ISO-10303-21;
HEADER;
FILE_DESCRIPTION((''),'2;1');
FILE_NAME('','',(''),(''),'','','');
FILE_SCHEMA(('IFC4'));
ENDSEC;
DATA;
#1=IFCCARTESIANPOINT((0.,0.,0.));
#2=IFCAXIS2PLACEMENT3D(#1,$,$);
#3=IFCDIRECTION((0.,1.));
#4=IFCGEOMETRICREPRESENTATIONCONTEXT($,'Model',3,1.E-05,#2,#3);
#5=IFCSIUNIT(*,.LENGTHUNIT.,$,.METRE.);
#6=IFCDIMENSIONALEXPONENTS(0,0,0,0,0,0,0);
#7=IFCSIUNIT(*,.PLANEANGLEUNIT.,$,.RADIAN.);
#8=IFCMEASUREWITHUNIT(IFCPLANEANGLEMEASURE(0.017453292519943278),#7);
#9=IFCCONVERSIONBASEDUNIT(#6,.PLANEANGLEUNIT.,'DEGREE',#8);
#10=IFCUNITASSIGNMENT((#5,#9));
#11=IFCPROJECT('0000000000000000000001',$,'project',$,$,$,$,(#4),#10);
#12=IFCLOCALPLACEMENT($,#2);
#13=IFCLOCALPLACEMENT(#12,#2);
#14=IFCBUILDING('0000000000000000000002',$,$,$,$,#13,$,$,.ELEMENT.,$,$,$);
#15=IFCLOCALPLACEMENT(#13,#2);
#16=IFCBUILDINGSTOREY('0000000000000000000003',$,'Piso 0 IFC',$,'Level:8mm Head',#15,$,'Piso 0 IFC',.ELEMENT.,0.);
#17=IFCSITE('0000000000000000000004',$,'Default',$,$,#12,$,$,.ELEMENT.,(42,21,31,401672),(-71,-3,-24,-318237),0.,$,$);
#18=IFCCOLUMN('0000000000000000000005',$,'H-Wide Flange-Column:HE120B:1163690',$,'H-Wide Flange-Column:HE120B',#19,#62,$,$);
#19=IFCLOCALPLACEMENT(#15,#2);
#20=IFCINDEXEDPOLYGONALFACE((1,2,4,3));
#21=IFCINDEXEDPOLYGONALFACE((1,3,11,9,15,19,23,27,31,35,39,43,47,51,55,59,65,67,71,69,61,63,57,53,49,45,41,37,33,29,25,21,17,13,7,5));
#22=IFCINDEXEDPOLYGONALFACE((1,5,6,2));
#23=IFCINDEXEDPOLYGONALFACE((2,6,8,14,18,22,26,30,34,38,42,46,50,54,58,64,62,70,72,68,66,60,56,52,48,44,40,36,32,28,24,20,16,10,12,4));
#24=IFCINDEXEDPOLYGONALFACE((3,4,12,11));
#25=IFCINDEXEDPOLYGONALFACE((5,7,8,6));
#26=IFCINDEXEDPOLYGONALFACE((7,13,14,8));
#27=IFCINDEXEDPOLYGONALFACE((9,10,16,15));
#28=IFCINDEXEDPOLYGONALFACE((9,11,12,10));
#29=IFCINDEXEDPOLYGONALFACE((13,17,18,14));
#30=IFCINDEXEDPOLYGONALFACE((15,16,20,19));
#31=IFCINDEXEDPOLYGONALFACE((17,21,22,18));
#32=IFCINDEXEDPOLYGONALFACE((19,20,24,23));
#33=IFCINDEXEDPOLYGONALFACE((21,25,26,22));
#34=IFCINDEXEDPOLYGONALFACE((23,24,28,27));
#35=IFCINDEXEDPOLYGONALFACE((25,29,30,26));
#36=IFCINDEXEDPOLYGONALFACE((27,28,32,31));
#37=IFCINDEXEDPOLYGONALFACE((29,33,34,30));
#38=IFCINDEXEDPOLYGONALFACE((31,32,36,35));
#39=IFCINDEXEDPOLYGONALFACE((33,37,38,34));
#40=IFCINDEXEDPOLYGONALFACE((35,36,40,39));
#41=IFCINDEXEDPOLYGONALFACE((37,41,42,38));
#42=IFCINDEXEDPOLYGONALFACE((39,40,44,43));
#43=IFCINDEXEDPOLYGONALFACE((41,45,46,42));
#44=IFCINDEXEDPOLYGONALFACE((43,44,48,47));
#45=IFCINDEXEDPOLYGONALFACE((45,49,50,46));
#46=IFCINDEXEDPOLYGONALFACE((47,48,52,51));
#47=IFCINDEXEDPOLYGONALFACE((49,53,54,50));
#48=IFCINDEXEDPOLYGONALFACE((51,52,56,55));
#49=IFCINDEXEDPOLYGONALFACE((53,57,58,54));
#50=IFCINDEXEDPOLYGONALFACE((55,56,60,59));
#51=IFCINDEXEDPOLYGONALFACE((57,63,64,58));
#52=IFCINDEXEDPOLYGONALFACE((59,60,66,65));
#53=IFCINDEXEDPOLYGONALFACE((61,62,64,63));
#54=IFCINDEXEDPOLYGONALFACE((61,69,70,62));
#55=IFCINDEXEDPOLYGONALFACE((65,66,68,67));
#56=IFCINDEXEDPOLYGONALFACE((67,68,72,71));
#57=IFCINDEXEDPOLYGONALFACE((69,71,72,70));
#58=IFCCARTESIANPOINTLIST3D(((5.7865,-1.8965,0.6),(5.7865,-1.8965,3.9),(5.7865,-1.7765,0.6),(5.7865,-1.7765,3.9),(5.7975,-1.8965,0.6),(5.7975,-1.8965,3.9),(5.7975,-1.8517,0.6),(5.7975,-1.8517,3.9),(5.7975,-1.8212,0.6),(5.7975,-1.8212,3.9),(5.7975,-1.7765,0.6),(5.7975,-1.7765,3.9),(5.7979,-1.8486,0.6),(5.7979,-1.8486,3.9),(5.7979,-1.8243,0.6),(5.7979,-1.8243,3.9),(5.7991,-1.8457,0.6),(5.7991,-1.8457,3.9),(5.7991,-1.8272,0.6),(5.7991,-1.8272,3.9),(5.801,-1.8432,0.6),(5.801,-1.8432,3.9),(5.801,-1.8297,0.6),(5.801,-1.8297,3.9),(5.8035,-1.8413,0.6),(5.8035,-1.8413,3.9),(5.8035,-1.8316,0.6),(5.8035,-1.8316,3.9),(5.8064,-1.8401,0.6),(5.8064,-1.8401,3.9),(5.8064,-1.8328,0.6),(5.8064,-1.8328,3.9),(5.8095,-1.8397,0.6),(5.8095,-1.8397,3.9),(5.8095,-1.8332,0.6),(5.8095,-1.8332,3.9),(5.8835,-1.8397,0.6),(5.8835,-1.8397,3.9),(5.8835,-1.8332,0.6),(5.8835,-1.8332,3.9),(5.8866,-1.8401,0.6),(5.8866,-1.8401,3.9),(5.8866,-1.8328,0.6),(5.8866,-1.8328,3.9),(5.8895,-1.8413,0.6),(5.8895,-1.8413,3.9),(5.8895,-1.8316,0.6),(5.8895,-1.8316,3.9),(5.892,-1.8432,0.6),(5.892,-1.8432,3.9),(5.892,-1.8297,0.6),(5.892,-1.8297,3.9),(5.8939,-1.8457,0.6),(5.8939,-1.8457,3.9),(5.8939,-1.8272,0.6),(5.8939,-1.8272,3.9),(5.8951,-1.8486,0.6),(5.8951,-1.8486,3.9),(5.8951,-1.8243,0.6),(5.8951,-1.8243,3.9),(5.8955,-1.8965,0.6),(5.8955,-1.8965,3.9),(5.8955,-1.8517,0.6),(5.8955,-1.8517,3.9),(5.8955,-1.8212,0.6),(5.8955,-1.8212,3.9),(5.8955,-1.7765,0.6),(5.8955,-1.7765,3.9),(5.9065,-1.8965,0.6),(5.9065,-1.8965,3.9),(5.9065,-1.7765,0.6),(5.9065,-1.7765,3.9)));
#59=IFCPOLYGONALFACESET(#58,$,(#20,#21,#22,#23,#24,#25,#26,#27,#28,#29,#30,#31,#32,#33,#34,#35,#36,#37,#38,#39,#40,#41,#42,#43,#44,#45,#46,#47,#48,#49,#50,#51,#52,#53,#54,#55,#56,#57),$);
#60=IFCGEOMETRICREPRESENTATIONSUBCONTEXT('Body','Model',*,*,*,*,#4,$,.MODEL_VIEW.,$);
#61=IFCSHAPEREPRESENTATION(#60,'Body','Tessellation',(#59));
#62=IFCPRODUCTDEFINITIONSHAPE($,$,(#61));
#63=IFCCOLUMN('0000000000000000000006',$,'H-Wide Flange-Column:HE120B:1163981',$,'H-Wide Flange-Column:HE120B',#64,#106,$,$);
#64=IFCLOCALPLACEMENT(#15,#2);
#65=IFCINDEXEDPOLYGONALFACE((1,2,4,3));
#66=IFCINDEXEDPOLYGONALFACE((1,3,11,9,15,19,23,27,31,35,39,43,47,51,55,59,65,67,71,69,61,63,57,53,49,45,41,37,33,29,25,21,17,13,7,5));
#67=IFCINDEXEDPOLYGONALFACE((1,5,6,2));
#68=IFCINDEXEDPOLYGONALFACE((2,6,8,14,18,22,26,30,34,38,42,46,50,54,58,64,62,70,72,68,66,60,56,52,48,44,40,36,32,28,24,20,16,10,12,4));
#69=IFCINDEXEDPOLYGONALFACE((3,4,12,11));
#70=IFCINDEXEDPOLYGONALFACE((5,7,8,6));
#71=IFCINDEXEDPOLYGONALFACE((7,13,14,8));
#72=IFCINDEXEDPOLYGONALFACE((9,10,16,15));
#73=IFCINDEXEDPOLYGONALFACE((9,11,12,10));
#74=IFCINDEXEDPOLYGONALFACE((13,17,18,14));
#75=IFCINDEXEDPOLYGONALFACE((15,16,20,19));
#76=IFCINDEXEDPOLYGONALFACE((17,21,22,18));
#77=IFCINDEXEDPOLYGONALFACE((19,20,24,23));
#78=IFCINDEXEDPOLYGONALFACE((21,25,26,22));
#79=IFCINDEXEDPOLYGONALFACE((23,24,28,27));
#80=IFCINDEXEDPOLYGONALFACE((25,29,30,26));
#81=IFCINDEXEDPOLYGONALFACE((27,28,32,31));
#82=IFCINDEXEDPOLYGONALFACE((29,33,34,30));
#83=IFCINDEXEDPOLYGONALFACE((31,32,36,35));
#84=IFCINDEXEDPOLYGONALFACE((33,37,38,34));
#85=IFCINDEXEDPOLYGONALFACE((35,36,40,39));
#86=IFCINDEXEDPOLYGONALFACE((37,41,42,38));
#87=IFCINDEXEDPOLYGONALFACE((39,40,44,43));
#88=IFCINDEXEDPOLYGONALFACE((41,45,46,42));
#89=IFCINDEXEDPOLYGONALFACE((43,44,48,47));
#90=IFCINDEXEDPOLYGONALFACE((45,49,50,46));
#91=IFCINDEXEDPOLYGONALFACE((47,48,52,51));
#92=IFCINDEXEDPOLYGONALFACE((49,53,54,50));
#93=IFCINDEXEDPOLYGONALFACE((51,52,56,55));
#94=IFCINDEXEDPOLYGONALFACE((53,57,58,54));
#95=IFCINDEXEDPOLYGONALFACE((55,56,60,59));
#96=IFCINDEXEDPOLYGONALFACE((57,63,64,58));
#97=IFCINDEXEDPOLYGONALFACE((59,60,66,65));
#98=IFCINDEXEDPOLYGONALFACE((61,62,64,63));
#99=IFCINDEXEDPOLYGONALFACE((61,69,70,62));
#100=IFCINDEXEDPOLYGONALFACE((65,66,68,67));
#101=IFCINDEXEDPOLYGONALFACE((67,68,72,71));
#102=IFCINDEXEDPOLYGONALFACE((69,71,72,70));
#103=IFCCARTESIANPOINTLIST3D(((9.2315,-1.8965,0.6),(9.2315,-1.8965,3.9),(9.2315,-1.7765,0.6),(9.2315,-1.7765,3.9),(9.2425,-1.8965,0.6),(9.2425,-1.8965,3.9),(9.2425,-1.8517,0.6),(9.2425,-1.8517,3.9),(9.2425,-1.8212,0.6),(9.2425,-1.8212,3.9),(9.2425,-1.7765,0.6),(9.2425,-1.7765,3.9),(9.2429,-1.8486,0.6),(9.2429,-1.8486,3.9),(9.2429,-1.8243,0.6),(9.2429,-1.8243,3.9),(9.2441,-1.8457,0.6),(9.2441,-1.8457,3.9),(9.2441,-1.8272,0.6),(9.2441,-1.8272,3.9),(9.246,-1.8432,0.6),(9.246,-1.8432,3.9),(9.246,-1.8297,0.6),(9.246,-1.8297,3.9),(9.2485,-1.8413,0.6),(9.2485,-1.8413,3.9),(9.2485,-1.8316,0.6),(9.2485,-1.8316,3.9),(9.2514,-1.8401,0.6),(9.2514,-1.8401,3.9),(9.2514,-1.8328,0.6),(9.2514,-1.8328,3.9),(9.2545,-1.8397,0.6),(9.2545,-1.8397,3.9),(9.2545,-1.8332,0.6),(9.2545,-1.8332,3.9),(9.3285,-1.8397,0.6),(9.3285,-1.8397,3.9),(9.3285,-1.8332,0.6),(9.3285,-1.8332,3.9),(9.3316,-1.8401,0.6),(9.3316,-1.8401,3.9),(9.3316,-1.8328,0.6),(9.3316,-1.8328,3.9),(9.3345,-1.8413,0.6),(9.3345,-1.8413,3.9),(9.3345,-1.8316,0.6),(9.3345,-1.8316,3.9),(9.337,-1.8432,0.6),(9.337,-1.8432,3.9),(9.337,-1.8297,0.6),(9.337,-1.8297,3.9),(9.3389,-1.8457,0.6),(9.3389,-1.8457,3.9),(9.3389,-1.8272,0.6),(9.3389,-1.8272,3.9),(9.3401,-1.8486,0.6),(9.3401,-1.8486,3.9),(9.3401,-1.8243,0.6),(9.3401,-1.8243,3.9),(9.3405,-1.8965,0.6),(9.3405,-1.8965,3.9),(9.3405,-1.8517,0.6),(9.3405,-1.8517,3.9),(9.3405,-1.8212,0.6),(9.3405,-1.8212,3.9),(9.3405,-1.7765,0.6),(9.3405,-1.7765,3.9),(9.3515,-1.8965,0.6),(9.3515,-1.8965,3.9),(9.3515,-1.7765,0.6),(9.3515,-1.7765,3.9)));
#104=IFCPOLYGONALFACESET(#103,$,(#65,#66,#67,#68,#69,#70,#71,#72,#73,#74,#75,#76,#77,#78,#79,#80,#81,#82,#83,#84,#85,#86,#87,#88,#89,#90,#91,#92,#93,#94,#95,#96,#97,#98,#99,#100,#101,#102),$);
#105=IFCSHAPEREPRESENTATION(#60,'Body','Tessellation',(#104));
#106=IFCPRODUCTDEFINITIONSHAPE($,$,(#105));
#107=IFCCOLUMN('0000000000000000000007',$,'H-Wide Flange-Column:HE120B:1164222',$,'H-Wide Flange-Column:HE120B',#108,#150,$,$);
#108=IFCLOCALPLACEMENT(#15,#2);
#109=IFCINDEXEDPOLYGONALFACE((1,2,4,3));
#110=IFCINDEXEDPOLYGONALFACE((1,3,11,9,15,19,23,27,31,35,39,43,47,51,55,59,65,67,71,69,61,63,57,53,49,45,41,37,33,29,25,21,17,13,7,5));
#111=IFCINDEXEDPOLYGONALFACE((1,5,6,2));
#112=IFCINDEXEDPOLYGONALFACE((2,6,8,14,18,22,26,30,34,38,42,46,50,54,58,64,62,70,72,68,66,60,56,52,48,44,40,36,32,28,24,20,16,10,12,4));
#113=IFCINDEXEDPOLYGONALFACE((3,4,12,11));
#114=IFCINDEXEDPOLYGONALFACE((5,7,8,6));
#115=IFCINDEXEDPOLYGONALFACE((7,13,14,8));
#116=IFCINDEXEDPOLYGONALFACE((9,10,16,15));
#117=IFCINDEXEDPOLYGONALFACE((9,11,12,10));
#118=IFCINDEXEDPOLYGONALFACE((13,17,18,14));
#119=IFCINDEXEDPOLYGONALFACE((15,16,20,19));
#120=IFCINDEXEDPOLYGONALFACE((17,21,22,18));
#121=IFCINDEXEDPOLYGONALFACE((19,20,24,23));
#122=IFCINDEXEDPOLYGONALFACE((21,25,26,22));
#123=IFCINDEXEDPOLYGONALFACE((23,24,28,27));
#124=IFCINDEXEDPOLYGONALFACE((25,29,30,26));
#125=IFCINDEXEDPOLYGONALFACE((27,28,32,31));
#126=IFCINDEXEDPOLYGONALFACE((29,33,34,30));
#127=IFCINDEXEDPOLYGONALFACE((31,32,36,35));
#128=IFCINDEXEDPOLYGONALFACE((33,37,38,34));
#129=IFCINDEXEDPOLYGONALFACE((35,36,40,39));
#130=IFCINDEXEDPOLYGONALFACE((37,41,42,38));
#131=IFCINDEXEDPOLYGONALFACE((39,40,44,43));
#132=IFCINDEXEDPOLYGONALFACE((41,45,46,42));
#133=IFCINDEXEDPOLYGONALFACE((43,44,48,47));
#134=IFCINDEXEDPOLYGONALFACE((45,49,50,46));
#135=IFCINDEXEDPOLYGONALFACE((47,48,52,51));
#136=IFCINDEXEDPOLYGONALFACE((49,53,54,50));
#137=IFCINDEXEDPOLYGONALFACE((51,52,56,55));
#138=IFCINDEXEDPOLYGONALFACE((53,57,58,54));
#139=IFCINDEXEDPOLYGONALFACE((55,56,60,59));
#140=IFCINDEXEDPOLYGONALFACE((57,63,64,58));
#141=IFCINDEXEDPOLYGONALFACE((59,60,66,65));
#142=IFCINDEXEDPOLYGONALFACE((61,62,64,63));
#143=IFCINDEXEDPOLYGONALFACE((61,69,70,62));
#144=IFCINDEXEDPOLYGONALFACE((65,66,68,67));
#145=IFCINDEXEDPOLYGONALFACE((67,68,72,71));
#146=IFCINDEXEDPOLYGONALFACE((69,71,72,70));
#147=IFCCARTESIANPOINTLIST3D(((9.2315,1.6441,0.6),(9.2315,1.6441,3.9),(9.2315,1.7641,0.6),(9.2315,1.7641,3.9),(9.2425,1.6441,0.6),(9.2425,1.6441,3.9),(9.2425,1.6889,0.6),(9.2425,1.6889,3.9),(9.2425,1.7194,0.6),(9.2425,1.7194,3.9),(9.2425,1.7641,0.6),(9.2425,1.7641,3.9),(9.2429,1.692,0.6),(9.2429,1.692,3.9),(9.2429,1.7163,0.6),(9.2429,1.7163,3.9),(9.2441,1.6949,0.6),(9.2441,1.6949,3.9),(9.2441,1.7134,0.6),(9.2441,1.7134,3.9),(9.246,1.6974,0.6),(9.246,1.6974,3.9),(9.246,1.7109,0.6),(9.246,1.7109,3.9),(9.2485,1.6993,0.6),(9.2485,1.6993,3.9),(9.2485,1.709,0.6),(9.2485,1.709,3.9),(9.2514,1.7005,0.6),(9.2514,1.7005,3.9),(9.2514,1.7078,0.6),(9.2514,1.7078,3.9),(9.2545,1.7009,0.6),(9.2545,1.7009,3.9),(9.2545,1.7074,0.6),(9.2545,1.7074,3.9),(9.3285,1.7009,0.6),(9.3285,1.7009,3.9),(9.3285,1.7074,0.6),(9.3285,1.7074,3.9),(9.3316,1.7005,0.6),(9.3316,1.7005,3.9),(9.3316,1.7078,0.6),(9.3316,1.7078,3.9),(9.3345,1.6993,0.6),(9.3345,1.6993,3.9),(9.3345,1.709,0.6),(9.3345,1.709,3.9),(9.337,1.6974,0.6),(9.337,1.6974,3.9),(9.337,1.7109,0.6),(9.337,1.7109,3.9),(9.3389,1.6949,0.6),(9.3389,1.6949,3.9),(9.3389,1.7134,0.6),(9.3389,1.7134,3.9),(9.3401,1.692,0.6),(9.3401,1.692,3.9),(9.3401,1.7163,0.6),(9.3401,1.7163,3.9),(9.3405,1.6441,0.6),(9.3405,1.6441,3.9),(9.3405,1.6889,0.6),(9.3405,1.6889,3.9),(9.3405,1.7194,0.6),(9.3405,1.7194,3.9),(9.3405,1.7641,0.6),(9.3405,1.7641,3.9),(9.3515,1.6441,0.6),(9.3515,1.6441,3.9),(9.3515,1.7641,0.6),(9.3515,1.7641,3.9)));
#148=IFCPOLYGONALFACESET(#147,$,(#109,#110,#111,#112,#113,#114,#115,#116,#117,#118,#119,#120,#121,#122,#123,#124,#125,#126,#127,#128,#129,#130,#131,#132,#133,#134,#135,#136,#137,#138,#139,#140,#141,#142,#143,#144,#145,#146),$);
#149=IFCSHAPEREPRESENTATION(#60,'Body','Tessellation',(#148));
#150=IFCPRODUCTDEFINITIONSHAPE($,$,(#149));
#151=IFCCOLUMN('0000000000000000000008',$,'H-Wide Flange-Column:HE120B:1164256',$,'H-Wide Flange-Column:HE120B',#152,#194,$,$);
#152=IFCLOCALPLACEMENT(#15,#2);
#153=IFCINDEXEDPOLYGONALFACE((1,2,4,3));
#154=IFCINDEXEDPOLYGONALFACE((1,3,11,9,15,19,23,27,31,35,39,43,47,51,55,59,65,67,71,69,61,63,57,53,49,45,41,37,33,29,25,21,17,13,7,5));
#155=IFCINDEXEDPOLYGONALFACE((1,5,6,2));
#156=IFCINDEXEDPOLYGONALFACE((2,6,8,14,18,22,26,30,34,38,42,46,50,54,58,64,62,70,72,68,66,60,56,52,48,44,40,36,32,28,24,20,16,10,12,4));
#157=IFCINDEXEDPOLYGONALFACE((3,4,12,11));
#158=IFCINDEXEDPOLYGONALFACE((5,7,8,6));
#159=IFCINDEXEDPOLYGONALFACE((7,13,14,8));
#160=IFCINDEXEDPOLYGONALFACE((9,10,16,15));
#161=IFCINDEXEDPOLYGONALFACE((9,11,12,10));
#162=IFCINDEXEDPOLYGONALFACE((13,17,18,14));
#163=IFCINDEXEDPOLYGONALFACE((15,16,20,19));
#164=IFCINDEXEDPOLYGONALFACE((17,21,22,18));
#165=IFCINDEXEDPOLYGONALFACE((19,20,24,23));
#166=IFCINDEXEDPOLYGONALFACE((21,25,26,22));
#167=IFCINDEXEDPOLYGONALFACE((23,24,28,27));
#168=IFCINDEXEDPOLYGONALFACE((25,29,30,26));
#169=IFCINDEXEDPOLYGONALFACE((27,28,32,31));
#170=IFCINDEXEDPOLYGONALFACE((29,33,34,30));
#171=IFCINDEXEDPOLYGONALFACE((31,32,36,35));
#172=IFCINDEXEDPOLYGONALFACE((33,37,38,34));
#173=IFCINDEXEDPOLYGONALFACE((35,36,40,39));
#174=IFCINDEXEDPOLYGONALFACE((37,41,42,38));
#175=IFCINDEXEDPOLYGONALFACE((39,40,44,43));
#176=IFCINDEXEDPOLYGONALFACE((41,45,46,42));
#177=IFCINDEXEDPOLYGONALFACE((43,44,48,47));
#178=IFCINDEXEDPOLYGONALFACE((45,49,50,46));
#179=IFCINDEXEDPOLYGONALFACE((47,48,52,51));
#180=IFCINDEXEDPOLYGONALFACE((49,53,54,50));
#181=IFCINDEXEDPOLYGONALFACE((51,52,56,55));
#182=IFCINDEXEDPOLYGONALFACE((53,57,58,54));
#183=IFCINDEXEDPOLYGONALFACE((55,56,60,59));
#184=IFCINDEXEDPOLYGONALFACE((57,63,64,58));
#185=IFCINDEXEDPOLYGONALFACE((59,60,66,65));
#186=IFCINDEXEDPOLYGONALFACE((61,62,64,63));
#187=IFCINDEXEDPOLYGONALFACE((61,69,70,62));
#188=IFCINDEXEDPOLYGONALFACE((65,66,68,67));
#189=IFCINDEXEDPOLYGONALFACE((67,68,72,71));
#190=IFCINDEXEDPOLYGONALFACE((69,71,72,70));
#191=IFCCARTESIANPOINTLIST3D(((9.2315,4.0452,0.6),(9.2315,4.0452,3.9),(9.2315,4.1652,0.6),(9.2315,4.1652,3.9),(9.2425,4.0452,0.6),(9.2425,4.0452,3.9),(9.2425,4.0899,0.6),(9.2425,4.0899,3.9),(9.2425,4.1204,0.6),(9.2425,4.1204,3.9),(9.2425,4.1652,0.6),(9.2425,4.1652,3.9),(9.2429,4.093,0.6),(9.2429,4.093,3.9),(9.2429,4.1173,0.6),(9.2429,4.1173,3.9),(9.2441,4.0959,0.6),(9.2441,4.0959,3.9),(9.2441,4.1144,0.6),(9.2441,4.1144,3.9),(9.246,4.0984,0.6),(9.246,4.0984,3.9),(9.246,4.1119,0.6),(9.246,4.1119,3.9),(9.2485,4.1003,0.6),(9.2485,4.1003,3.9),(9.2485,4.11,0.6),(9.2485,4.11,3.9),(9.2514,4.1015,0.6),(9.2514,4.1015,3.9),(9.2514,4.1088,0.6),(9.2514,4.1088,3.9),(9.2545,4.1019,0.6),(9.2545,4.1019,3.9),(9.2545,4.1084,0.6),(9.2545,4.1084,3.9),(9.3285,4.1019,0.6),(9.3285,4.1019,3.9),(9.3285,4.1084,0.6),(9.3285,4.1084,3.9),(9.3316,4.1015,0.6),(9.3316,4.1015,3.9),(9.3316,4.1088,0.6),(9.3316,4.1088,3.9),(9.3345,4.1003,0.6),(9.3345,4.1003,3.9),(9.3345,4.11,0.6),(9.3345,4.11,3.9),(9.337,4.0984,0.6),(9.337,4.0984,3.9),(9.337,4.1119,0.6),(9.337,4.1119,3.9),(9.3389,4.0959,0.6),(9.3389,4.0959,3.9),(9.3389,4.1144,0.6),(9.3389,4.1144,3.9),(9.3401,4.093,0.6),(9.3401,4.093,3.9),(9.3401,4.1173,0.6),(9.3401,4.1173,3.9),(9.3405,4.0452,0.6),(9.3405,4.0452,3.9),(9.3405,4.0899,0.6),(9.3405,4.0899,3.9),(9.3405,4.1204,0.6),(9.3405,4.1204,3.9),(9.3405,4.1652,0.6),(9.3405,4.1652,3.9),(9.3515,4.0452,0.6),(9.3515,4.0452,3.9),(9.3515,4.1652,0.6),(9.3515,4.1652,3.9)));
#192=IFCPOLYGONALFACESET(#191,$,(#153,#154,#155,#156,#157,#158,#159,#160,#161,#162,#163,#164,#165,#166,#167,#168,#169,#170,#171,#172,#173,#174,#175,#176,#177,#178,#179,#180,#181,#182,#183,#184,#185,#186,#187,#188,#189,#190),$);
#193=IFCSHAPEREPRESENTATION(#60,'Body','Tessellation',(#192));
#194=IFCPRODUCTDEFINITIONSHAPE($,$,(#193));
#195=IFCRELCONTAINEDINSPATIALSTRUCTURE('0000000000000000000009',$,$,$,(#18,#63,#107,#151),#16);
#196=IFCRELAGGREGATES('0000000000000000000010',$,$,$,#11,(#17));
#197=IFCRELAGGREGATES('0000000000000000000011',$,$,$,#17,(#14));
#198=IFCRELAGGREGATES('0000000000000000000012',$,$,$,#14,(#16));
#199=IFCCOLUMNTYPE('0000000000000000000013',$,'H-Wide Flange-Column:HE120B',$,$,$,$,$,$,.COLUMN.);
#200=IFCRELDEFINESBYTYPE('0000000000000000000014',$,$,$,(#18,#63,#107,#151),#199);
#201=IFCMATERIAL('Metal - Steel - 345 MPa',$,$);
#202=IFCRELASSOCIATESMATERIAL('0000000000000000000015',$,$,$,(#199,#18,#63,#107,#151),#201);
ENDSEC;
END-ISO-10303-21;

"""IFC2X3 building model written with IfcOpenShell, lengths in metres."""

from ifc_helpers import new_model, entity, si_unit, converted_unit, direction, frame, frame_2d, origin, place, context, subcontext, project, spatial, i_section, extrude, source, transform, mapped, material, type_object, type_shapes, element, save


model = new_model("IFC2X3")

# Units and contexts
model_context = context("Model", 3, precision=1e-05, world=origin(), true_north=direction((0.0, 1.0)))
body_context = subcontext(model_context, "Body", "Model", "MODEL_VIEW")
ifc_project = project(units=[si_unit("LENGTHUNIT", "METRE"), converted_unit("PLANEANGLEUNIT", "DEGREE", entity("IfcPlaneAngleMeasure", 0.017453292519943278), si_unit("PLANEANGLEUNIT", "RADIAN"), dimensions=[0, 0, 0, 0, 0, 0, 0])], contexts=[model_context])

# Site, building, storey
site_placement = place(None, origin())
site = spatial("IfcSite", under=ifc_project, at=site_placement, Name="Default", CompositionType="ELEMENT", RefLatitude=(42, 21, 31, 401672), RefLongitude=(-71, -3, -24, -318237), RefElevation=0.0)
building_placement = place(site_placement, origin())
building = spatial("IfcBuilding", under=site, at=building_placement, CompositionType="ELEMENT")
storey_placement = place(building_placement, origin())
storey = spatial("IfcBuildingStorey", under=building, at=storey_placement, Name="Piso 0 IFC", ObjectType="Level:8mm Head", LongName="Piso 0 IFC", CompositionType="ELEMENT", Elevation=0.0)

# Columns
ifc_material_1 = material(Name="Metal - Steel - 345 MPa")
column_type_1 = type_object("IfcColumnType", Name="H-Wide Flange-Column:HE120B", PredefinedType="COLUMN", material=ifc_material_1)
shared_shape_1 = source(origin(), body_context, "Body", "SweptSolid", [
    extrude(i_section(OverallWidth=0.12, OverallDepth=0.12, WebThickness=0.0065, FlangeThickness=0.011, FilletRadius=0.012, at=frame_2d((0.0, 0.0), x_axis=(1.0, 0.0))), frame((0.0, 0.0, 0.6), z_axis=(0.0, 0.0, 1.0), x_axis=(-1.0, 0.0, 0.0)), (0.0, 0.0, 1.0), 3.3),
])
type_shapes(column_type_1, [shared_shape_1])
for number, where, z_axis, x_axis, name in (
    (1, (5.8465, -1.8365, 0.0), (0.0, 0.0, 1.0), (0.0, 1.0, 0.0), "H-Wide Flange-Column:HE120B:1163690"),
    (2, (9.2915, -1.8365, 0.0), (0.0, 0.0, 1.0), (0.0, 1.0, 0.0), "H-Wide Flange-Column:HE120B:1163981"),
    (3, (9.2915, 1.7041, 0.0), (0.0, 0.0, 1.0), (0.0, -1.0, 0.0), "H-Wide Flange-Column:HE120B:1164222"),
    (4, (9.2915, 4.1052, 0.0), (0.0, 0.0, 1.0), (0.0, -1.0, 0.0), "H-Wide Flange-Column:HE120B:1164256"),
):
    element("IfcColumn", number, at=place(storey_placement, frame(where, z_axis=z_axis, x_axis=x_axis)), inside=storey, type_object=column_type_1, material=ifc_material_1, Name=name, ObjectType="H-Wide Flange-Column:HE120B", context=body_context, shape_type="MappedRepresentation", body=[
        mapped(shared_shape_1, transform((0.0, 0.0, 0.0), scale=1.0)),
    ])

save(model, "model.ifc")
